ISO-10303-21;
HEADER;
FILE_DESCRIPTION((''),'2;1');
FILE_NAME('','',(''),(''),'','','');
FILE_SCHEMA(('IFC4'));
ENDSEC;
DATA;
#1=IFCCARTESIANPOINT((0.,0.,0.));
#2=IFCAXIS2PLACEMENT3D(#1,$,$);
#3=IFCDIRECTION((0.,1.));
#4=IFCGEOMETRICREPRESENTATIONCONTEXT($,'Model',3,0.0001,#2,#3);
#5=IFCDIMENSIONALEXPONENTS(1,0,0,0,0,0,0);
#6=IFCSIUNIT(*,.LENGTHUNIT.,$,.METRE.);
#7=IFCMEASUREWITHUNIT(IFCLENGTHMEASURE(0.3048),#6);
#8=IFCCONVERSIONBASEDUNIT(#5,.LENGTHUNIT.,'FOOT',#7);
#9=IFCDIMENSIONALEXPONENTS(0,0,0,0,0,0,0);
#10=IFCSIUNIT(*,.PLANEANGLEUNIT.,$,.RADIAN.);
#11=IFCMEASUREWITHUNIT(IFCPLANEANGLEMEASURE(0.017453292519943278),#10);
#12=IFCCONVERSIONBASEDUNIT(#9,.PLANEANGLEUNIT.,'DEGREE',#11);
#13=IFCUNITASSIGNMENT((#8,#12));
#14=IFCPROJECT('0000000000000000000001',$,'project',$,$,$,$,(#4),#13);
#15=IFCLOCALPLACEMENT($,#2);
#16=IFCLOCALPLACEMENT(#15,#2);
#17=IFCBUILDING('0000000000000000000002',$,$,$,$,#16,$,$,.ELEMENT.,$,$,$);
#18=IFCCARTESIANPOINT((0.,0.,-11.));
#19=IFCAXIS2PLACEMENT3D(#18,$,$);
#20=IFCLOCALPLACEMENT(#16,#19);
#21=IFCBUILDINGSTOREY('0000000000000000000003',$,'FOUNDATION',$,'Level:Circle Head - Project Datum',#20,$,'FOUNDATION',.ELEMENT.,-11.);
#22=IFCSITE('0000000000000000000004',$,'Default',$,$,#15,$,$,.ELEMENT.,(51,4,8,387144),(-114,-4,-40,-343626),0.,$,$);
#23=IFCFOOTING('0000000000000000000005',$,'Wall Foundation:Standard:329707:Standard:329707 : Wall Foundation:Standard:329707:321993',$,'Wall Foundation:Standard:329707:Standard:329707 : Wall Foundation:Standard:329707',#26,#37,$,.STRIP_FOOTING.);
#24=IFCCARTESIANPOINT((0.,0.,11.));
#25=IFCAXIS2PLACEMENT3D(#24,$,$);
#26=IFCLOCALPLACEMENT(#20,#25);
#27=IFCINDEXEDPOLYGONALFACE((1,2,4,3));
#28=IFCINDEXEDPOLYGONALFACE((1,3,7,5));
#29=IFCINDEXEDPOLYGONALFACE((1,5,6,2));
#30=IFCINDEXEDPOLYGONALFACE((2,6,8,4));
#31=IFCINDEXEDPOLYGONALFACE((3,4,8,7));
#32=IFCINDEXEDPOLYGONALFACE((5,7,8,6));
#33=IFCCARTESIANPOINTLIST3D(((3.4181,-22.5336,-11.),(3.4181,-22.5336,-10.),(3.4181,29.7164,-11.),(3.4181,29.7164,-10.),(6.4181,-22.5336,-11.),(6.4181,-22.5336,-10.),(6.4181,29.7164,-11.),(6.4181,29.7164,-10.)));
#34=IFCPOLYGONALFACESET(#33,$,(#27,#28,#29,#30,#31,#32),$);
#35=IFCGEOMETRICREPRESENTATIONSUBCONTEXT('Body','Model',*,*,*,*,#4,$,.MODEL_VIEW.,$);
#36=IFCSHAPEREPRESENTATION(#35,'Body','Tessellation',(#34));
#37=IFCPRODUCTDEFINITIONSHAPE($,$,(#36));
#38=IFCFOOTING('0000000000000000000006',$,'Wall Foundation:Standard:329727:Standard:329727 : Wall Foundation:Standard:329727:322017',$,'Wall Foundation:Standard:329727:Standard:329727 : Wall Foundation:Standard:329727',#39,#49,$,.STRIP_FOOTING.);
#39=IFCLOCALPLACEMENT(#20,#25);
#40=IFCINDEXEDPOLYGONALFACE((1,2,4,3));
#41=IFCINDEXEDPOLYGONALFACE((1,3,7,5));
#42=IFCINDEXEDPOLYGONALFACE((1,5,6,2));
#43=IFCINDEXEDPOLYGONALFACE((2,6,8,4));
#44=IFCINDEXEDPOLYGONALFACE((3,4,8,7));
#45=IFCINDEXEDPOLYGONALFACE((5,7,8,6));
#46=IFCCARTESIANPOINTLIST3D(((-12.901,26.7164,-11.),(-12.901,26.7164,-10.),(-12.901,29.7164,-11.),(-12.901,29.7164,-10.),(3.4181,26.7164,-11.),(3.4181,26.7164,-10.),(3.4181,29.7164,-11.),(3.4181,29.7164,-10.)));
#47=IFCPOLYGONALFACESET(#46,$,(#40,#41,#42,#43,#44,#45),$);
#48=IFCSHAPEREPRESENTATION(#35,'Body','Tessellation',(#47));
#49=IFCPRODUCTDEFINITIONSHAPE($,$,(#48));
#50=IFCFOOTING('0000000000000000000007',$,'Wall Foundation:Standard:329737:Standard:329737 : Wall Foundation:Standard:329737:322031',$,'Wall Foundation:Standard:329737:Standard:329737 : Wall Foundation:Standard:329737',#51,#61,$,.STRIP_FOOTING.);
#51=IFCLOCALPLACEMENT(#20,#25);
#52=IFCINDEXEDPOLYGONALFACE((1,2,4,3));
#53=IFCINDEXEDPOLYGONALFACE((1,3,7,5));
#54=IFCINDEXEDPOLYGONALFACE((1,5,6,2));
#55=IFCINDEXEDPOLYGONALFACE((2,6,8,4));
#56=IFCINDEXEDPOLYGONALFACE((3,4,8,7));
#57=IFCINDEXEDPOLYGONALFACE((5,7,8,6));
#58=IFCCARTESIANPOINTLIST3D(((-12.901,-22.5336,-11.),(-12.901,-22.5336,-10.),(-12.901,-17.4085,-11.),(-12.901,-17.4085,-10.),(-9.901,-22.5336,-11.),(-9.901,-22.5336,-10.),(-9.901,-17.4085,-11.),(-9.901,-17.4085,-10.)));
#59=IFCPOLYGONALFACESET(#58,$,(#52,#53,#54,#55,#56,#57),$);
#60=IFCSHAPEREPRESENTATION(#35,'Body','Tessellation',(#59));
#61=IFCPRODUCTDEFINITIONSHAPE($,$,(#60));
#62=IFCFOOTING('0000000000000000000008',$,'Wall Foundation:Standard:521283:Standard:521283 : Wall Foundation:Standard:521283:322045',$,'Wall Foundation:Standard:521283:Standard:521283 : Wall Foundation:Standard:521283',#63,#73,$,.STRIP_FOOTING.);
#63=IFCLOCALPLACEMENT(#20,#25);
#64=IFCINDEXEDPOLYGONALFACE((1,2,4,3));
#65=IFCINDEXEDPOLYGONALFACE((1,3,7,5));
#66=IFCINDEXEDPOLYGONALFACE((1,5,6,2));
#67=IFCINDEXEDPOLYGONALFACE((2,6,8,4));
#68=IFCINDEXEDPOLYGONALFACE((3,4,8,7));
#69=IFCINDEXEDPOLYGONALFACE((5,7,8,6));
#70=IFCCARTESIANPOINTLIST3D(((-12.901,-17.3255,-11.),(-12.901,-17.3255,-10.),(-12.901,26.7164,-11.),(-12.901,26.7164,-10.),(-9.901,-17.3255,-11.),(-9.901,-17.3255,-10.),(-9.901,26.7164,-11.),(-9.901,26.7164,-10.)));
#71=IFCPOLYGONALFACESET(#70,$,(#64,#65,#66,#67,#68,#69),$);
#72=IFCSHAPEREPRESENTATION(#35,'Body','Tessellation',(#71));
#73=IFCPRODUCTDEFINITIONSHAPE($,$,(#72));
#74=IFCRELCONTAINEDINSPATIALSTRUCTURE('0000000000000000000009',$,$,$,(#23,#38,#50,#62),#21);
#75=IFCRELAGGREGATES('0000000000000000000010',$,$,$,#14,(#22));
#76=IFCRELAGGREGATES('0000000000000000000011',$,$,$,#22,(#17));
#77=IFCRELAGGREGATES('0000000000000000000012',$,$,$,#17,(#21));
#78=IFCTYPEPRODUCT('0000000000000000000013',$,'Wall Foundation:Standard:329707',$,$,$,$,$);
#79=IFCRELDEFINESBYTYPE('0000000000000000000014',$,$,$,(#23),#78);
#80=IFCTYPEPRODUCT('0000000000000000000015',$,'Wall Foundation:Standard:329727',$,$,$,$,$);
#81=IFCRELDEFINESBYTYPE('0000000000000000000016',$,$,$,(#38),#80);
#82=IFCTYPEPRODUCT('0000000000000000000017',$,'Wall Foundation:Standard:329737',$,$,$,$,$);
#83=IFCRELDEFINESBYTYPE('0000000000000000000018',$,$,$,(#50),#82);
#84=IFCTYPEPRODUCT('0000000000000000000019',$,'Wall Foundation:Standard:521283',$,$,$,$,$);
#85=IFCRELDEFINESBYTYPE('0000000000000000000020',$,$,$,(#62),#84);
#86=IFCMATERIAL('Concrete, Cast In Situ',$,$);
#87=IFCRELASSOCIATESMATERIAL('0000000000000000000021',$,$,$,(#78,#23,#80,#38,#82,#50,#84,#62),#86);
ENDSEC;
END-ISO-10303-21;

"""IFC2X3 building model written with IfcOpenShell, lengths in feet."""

from ifc_helpers import new_model, entity, si_unit, converted_unit, direction, frame, frame_2d, origin, origin_2d_with_axis, place, context, subcontext, project, spatial, rectangle, extrude, source, transform, mapped, material, type_object, type_shapes, element, save


model = new_model("IFC2X3")

# Units and contexts
model_context = context("Model", 3, precision=0.0001, world=origin(), true_north=direction((0.0, 1.0)))
body_context = subcontext(model_context, "Body", "Model", "MODEL_VIEW")
ifc_project = project(units=[converted_unit("LENGTHUNIT", "FOOT", entity("IfcLengthMeasure", 0.3048), si_unit("LENGTHUNIT", "METRE"), dimensions=[1, 0, 0, 0, 0, 0, 0]), converted_unit("PLANEANGLEUNIT", "DEGREE", entity("IfcPlaneAngleMeasure", 0.017453292519943278), si_unit("PLANEANGLEUNIT", "RADIAN"), dimensions=[0, 0, 0, 0, 0, 0, 0])], contexts=[model_context])

# Site, building, storey
site_placement = place(None, origin())
site = spatial("IfcSite", under=ifc_project, at=site_placement, Name="Default", CompositionType="ELEMENT", RefLatitude=(51, 4, 8, 387144), RefLongitude=(-114, -4, -40, -343626), RefElevation=0.0)
building_placement = place(site_placement, origin())
building = spatial("IfcBuilding", under=site, at=building_placement, CompositionType="ELEMENT")
storey_placement = place(building_placement, frame((0.0, 0.0, -11.0)))
storey = spatial("IfcBuildingStorey", under=building, at=storey_placement, Name="FOUNDATION", ObjectType="Level:Circle Head - Project Datum", LongName="FOUNDATION", CompositionType="ELEMENT", Elevation=-11.0)

# Footings
ifc_material = material(Name="Concrete, Cast In Situ")
type_product_1 = type_object("IfcTypeProduct", Name="Wall Foundation:Standard:329707", material=ifc_material)
shared_shape_1 = source(origin(), body_context, "Body", "SweptSolid", [
    extrude(rectangle(XDim=3.0, YDim=52.25, at=frame_2d((0.0, 0.0), x_axis=(1.0, 0.0))), frame((4.9181, 3.5914, -11.0)), (0.0, 0.0, 1.0), 1.0),
])
type_shapes(type_product_1, [shared_shape_1])
footing_1_placement = place(storey_placement, frame((0.0, 0.0, 11.0)))
element("IfcFooting", 1, at=footing_1_placement, inside=storey, type_object=type_product_1, material=ifc_material, Name="Wall Foundation:Standard:329707:Standard:329707 : Wall Foundation:Standard:329707:321993", ObjectType="Wall Foundation:Standard:329707:Standard:329707 : Wall Foundation:Standard:329707", PredefinedType="STRIP_FOOTING", context=body_context, shape_type="MappedRepresentation", body=[
    mapped(shared_shape_1, transform((0.0, 0.0, 0.0), scale=1.0)),
])
type_product_2 = type_object("IfcTypeProduct", Name="Wall Foundation:Standard:329727", material=ifc_material)
shared_shape_2 = source(origin(), body_context, "Body", "SweptSolid", [
    extrude(rectangle(XDim=3.0, YDim=16.3192, at=origin_2d_with_axis()), frame((-4.7415, 28.2164, -11.0), z_axis=(0.0, 0.0, 1.0), x_axis=(0.0, 1.0, 0.0)), (0.0, 0.0, 1.0), 1.0),
])
type_shapes(type_product_2, [shared_shape_2])
footing_2_placement = place(storey_placement, frame((0.0, 0.0, 11.0)))
element("IfcFooting", 2, at=footing_2_placement, inside=storey, type_object=type_product_2, material=ifc_material, Name="Wall Foundation:Standard:329727:Standard:329727 : Wall Foundation:Standard:329727:322017", ObjectType="Wall Foundation:Standard:329727:Standard:329727 : Wall Foundation:Standard:329727", PredefinedType="STRIP_FOOTING", context=body_context, shape_type="MappedRepresentation", body=[
    mapped(shared_shape_2, transform((0.0, 0.0, 0.0), scale=1.0)),
])
type_product_3 = type_object("IfcTypeProduct", Name="Wall Foundation:Standard:329737", material=ifc_material)
shared_shape_3 = source(origin(), body_context, "Body", "SweptSolid", [
    extrude(rectangle(XDim=3.0, YDim=5.1252, at=frame_2d((0.0, 0.0), x_axis=(1.0, 0.0))), frame((-11.401, -19.971, -11.0), z_axis=(0.0, 0.0, 1.0), x_axis=(-1.0, 0.0, 0.0)), (0.0, 0.0, 1.0), 1.0),
])
type_shapes(type_product_3, [shared_shape_3])
footing_3_placement = place(storey_placement, frame((0.0, 0.0, 11.0)))
element("IfcFooting", 3, at=footing_3_placement, inside=storey, type_object=type_product_3, material=ifc_material, Name="Wall Foundation:Standard:329737:Standard:329737 : Wall Foundation:Standard:329737:322031", ObjectType="Wall Foundation:Standard:329737:Standard:329737 : Wall Foundation:Standard:329737", PredefinedType="STRIP_FOOTING", context=body_context, shape_type="MappedRepresentation", body=[
    mapped(shared_shape_3, transform((0.0, 0.0, 0.0), scale=1.0)),
])
type_product_4 = type_object("IfcTypeProduct", Name="Wall Foundation:Standard:521283", material=ifc_material)
shared_shape_4 = source(origin(), body_context, "Body", "SweptSolid", [
    extrude(rectangle(XDim=3.0, YDim=44.0418, at=origin_2d_with_axis()), frame((-11.401, 4.6955, -11.0), z_axis=(0.0, 0.0, 1.0), x_axis=(-1.0, 0.0, 0.0)), (0.0, 0.0, 1.0), 1.0),
])
type_shapes(type_product_4, [shared_shape_4])
footing_4_placement = place(storey_placement, frame((0.0, 0.0, 11.0)))
element("IfcFooting", 4, at=footing_4_placement, inside=storey, type_object=type_product_4, material=ifc_material, Name="Wall Foundation:Standard:521283:Standard:521283 : Wall Foundation:Standard:521283:322045", ObjectType="Wall Foundation:Standard:521283:Standard:521283 : Wall Foundation:Standard:521283", PredefinedType="STRIP_FOOTING", context=body_context, shape_type="MappedRepresentation", body=[
    mapped(shared_shape_4, transform((0.0, 0.0, 0.0), scale=1.0)),
])

save(model, "model.ifc")
